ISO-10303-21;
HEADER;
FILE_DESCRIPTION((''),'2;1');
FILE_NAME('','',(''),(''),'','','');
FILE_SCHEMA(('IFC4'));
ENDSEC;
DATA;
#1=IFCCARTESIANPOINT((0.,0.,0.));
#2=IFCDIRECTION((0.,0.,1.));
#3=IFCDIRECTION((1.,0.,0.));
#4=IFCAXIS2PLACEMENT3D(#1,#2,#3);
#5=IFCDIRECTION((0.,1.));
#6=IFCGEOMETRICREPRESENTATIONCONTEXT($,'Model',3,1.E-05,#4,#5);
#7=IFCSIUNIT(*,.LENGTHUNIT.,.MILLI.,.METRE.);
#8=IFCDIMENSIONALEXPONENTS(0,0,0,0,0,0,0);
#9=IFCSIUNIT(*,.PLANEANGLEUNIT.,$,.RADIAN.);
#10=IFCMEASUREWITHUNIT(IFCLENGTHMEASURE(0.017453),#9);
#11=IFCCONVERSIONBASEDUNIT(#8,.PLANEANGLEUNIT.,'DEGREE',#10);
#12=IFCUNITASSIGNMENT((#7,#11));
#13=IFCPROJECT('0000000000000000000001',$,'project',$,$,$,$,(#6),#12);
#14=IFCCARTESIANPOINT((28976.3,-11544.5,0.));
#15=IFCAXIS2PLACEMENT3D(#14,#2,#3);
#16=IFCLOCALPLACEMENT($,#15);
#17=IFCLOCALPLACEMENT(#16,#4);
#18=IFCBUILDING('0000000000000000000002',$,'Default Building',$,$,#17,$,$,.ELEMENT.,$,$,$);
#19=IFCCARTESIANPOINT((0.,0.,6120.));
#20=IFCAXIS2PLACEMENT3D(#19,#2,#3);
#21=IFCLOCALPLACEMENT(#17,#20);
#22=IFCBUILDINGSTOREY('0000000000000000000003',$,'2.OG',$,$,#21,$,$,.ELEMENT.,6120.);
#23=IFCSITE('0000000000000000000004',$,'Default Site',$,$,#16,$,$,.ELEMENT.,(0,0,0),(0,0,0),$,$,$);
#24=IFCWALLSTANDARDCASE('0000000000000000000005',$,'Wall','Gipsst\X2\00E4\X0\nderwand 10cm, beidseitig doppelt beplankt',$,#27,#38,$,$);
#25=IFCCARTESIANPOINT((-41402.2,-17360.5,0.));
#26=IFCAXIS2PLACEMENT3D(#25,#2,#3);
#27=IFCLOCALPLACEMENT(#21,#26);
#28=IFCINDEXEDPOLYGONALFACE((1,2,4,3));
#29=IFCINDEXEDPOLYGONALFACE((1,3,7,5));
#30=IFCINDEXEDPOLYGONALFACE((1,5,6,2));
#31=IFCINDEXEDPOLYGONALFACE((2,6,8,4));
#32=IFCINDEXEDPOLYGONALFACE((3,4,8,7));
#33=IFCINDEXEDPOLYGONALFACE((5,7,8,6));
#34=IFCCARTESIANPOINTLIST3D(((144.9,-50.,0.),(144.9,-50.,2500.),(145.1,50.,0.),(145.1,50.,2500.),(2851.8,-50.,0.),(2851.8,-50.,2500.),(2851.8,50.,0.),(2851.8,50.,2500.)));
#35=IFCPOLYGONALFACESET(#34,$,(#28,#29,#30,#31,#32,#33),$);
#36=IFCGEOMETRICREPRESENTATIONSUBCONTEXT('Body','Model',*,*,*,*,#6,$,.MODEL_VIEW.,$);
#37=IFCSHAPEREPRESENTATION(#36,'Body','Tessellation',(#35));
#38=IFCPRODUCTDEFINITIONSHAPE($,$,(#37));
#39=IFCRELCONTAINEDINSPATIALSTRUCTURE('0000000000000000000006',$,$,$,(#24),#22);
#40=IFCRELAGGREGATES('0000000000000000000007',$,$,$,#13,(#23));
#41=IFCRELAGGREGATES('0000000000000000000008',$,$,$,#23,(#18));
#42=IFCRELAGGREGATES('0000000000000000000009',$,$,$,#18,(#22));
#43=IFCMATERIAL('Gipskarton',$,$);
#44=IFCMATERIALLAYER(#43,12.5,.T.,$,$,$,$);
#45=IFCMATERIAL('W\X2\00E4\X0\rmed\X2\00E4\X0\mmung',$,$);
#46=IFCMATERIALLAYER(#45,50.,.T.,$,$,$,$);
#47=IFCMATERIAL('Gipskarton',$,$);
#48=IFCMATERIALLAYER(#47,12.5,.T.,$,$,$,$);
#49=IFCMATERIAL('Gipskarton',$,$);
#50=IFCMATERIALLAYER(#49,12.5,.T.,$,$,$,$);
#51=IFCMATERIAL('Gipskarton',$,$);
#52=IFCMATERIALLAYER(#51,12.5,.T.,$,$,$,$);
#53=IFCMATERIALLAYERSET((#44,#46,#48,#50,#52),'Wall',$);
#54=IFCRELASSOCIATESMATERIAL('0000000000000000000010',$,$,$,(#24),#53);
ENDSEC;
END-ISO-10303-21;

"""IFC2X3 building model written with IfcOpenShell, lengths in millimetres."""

from ifc_helpers import new_model, entity, si_unit, converted_unit, direction, frame, origin_with_axes, place, context, subcontext, project, spatial, polyline, outline, extrude, material, layer, layer_set, layer_usage, element, save


model = new_model("IFC2X3")

# Units and contexts
model_context = context("Model", 3, precision=1e-05, world=origin_with_axes(), true_north=direction((0.0, 1.0)))
body_context = subcontext(model_context, "Body", "Model", "MODEL_VIEW")
ifc_project = project(units=[si_unit("LENGTHUNIT", "METRE", prefix="MILLI"), converted_unit("PLANEANGLEUNIT", "DEGREE", entity("IfcLengthMeasure", 0.017453), si_unit("PLANEANGLEUNIT", "RADIAN"), dimensions=[0, 0, 0, 0, 0, 0, 0])], contexts=[model_context])

# Site, building, storey
site_placement = place(None, frame((28976.3, -11544.5, 0.0), z_axis=(0.0, 0.0, 1.0), x_axis=(1.0, 0.0, 0.0)))
site = spatial("IfcSite", under=ifc_project, at=site_placement, Name="Default Site", CompositionType="ELEMENT", RefLatitude=(0, 0, 0), RefLongitude=(0, 0, 0))
building_placement = place(site_placement, origin_with_axes())
building = spatial("IfcBuilding", under=site, at=building_placement, Name="Default Building", CompositionType="ELEMENT")
storey_placement = place(building_placement, frame((0.0, 0.0, 6120.0), z_axis=(0.0, 0.0, 1.0), x_axis=(1.0, 0.0, 0.0)))
storey = spatial("IfcBuildingStorey", under=building, at=storey_placement, Name="2.OG", CompositionType="ELEMENT", Elevation=6120.0)

# Wall
ifc_material_1 = material(Name="Gipskarton")
ifc_layer_1 = layer(ifc_material_1, 12.5, ventilated=True)
ifc_material_2 = material(Name="Wärmedämmung")
ifc_layer_2 = layer(ifc_material_2, 50.0, ventilated=True)
ifc_material_3 = material(Name="Gipskarton")
ifc_layer_3 = layer(ifc_material_3, 12.5, ventilated=True)
ifc_material_4 = material(Name="Gipskarton")
ifc_layer_4 = layer(ifc_material_4, 12.5, ventilated=True)
ifc_material_5 = material(Name="Gipskarton")
ifc_layer_5 = layer(ifc_material_5, 12.5, ventilated=True)
ifc_layer_set_1 = layer_set([ifc_layer_1, ifc_layer_2, ifc_layer_3, ifc_layer_4, ifc_layer_5], Name="Wall")
ifc_layer_usage_1 = layer_usage(ifc_layer_set_1, "AXIS2", "POSITIVE", -50.0)
wall_1_placement = place(storey_placement, frame((-41402.2, -17360.5, 0.0), z_axis=(0.0, 0.0, 1.0), x_axis=(1.0, 0.0, 0.0)))
element("IfcWallStandardCase", 1, at=wall_1_placement, inside=storey, material=ifc_layer_usage_1, Name="Wall", Description="Gipsständerwand 10cm, beidseitig doppelt beplankt", context=body_context, shape_type="SweptSolid", body=[
    extrude(outline(polyline([(2851.8, 50.0), (145.1, 50.0), (144.9, -50.0), (2851.8, -50.0), (2851.8, 50.0)])), origin_with_axes(), (0.0, 0.0, 1.0), 2500.0),
])

save(model, "model.ifc")
